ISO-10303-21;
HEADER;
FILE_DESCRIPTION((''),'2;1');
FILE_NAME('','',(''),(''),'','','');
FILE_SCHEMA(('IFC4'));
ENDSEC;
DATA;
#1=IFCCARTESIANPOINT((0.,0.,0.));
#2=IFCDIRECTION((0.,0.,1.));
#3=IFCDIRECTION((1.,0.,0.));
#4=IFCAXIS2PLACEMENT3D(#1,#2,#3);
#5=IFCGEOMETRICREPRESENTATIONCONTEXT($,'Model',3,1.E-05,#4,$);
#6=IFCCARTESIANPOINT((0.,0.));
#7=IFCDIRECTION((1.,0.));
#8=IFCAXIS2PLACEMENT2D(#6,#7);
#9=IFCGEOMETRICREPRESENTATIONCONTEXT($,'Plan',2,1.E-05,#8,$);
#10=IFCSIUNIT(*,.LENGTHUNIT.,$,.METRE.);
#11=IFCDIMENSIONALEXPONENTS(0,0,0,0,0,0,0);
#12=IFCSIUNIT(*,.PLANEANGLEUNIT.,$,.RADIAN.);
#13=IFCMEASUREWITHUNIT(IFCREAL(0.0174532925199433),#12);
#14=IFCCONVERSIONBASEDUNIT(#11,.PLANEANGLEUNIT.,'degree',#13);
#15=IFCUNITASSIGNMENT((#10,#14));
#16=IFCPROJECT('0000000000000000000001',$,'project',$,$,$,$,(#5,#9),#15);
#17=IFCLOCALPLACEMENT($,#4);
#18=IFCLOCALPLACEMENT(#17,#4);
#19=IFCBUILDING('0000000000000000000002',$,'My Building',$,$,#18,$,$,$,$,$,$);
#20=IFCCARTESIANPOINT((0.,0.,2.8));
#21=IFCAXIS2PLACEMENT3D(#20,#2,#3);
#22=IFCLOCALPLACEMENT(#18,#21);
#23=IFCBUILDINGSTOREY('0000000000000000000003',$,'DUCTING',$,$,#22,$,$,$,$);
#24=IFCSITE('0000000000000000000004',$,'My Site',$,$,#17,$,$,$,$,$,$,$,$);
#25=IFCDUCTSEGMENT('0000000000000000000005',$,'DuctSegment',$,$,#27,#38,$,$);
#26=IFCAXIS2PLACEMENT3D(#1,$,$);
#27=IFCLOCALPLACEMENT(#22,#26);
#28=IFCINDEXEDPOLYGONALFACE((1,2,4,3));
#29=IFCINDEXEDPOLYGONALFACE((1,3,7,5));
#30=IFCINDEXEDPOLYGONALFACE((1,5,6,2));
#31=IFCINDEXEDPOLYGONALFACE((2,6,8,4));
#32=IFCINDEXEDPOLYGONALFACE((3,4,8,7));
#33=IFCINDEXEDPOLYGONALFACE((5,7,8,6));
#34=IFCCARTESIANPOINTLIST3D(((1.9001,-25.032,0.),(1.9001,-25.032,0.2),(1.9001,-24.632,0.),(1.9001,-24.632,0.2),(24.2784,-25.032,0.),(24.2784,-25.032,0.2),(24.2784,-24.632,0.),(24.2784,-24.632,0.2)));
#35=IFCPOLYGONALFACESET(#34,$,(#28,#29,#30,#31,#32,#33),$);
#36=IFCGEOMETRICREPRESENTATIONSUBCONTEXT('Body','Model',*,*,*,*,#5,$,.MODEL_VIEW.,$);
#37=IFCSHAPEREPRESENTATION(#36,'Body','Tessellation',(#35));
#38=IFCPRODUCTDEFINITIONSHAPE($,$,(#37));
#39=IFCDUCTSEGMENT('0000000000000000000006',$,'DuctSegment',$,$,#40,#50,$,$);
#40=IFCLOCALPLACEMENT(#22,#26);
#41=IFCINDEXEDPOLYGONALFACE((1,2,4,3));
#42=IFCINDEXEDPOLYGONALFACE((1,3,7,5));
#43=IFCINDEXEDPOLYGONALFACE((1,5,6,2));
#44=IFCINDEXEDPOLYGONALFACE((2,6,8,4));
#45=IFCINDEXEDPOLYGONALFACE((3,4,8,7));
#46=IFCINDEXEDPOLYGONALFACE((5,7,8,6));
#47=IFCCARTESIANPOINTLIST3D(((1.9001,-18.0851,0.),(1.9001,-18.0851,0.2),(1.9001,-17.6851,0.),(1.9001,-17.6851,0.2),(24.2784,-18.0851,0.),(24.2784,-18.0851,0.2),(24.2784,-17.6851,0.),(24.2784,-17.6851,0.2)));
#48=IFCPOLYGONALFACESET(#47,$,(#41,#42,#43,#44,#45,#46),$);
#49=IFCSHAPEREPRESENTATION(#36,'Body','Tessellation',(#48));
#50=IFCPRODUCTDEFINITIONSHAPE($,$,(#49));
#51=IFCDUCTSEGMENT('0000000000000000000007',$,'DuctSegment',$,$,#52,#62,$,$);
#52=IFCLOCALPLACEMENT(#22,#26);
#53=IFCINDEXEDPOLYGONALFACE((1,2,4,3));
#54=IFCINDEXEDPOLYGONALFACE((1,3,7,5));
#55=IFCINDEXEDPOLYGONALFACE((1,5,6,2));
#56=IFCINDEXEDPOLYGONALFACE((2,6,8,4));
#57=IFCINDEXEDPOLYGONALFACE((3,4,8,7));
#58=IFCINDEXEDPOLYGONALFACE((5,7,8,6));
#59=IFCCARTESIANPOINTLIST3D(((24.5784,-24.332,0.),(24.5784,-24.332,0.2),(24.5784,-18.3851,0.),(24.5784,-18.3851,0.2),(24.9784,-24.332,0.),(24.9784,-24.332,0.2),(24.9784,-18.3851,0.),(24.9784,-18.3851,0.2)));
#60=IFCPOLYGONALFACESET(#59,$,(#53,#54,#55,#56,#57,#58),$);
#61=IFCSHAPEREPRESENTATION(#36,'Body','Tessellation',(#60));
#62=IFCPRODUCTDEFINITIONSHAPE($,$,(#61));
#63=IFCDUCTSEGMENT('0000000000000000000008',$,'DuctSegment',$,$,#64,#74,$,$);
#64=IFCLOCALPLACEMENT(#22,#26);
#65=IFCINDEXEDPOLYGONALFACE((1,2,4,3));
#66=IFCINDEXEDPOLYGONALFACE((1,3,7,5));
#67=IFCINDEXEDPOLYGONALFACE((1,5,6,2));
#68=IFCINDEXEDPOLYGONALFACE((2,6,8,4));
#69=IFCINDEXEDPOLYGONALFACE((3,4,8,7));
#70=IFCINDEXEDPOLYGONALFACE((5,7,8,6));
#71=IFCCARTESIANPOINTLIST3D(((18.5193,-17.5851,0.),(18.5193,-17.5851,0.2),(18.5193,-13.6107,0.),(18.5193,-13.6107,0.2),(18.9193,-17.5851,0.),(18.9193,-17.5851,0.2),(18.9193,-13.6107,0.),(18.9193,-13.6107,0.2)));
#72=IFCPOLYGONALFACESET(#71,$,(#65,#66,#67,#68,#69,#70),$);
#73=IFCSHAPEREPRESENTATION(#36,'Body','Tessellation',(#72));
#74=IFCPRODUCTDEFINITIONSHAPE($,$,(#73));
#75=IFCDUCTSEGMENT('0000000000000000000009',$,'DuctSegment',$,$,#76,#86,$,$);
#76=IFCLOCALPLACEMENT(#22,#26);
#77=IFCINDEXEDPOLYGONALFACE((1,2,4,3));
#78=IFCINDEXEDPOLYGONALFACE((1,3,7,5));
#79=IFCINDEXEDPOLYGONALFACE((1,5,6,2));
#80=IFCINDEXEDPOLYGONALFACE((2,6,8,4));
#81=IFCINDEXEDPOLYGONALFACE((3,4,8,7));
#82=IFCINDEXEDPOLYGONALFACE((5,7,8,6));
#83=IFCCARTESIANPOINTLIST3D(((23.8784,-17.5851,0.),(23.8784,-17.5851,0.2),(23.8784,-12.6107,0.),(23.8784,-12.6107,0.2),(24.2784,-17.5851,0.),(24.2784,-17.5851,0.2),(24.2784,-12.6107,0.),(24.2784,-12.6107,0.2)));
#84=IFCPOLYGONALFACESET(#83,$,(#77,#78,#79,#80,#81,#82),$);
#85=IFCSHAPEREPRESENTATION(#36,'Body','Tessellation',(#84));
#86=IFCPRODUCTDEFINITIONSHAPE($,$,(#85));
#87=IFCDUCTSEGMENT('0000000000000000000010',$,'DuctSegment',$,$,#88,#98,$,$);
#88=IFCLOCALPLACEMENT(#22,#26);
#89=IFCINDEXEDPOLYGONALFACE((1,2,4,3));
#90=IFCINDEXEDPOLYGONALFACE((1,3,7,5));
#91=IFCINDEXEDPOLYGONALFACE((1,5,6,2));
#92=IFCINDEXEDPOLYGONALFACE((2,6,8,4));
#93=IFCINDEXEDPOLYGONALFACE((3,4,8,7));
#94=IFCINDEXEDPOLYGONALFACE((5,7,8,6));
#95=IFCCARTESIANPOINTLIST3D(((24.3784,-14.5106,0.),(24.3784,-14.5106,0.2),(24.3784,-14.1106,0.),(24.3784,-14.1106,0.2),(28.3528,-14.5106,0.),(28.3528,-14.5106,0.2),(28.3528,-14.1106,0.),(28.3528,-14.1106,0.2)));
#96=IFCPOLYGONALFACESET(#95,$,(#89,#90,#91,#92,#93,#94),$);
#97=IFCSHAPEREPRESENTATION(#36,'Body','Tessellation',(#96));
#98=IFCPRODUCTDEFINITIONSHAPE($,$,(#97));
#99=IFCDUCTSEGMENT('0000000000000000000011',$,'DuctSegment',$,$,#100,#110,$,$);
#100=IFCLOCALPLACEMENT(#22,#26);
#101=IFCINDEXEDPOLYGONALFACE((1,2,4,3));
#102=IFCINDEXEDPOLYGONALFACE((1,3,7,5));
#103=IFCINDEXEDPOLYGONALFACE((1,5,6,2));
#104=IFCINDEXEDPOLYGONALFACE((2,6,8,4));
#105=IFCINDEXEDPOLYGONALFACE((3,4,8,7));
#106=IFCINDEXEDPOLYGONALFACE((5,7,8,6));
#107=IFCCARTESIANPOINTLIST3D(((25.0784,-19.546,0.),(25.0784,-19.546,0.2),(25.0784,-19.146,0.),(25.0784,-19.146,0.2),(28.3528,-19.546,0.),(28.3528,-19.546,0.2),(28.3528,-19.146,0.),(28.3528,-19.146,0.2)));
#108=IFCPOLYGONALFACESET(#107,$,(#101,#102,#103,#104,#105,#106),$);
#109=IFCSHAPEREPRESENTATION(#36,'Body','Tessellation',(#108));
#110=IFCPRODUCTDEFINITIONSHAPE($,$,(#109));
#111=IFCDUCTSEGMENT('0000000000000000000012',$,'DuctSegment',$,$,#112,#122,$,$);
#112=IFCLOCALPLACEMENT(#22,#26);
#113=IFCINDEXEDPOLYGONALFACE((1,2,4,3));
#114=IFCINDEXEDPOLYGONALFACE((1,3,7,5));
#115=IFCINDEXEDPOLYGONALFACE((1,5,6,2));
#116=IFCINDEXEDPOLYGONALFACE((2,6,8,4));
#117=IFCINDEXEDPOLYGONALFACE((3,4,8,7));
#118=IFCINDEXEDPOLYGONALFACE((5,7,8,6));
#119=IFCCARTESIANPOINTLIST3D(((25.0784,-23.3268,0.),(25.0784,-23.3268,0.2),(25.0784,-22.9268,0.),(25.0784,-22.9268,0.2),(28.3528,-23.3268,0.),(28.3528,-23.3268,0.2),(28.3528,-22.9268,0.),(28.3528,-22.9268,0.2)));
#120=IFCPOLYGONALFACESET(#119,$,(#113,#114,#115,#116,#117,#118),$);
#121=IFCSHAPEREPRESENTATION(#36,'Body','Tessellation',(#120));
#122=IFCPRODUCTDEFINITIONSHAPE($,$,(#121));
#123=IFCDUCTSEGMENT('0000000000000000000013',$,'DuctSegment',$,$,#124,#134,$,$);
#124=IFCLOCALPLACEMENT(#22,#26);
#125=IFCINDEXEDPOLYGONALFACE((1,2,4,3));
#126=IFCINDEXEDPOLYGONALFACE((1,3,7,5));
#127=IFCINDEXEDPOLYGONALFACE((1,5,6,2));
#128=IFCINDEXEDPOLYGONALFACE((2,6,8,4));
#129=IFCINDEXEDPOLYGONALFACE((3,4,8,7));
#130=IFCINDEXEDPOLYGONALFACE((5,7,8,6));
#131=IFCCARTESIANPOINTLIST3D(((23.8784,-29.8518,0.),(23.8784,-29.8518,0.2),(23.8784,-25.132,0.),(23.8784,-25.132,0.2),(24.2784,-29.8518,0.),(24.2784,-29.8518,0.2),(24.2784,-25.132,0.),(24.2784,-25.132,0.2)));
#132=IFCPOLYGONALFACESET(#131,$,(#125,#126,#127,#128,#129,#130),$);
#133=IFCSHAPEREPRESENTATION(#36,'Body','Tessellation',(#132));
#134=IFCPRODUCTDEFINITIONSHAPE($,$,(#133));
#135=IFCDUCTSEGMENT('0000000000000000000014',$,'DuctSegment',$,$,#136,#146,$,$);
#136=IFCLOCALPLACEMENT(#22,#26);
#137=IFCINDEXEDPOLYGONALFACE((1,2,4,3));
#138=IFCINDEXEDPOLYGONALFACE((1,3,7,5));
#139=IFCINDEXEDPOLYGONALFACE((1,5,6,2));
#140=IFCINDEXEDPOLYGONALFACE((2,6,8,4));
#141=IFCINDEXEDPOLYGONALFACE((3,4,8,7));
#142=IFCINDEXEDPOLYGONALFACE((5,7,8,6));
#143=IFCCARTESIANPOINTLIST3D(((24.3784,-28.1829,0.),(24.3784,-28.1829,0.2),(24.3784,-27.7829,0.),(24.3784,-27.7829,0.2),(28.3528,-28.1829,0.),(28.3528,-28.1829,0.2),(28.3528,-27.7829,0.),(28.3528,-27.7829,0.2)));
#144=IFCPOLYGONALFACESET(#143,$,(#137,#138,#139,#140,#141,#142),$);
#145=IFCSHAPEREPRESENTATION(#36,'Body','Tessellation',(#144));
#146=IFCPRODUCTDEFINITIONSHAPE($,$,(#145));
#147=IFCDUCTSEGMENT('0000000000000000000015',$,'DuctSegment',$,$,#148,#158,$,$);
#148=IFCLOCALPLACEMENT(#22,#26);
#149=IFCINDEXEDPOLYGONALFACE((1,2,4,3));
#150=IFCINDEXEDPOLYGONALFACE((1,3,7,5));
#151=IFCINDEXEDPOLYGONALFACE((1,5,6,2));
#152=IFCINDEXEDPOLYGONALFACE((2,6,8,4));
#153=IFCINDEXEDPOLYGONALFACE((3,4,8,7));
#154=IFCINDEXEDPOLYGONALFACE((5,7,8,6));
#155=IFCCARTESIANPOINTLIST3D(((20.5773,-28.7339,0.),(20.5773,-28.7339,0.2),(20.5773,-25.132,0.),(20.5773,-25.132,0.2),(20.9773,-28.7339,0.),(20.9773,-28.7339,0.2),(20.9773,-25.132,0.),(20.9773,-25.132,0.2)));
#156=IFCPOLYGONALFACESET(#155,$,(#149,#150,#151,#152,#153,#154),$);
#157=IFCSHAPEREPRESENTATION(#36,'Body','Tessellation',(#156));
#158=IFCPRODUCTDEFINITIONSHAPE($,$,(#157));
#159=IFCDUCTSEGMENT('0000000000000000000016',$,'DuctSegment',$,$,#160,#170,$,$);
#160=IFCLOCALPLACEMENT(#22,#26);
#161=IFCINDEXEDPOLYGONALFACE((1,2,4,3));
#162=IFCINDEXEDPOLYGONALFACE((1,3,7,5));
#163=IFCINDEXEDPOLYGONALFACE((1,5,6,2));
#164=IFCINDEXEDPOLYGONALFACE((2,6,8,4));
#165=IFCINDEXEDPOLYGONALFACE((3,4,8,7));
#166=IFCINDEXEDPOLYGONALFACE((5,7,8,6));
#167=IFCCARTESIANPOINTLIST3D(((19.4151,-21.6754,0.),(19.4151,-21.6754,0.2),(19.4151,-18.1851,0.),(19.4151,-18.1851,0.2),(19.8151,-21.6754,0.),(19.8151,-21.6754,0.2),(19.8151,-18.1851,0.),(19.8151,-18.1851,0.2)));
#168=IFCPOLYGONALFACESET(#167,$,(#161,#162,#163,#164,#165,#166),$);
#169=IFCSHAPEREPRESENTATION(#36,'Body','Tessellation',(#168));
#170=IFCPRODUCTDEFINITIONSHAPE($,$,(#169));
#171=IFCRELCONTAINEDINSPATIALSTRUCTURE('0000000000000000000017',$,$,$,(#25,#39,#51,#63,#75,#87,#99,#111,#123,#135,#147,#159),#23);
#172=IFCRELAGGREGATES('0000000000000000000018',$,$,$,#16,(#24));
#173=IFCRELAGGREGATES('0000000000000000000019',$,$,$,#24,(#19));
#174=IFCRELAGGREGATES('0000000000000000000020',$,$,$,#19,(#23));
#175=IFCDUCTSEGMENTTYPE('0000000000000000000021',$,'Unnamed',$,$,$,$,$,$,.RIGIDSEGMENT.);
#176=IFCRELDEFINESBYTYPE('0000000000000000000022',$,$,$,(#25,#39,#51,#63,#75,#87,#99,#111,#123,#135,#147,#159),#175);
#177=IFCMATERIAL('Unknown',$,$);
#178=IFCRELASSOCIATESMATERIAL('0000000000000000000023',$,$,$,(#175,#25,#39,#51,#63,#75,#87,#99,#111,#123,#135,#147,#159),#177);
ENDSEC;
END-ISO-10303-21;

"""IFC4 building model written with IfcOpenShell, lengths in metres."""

from ifc_helpers import new_model, entity, si_unit, converted_unit, frame, origin_with_axes, origin_2d_with_axis, place, context, subcontext, project, spatial, rectangle, extrude, material, material_profile, profile_set, profile_usage, type_object, element, save


model = new_model("IFC4")

# Units and contexts
model_context = context("Model", 3, precision=1e-05, world=origin_with_axes())
plan_context = context("Plan", 2, precision=1e-05, world=origin_2d_with_axis())
body_context = subcontext(model_context, "Body", "Model", "MODEL_VIEW")
ifc_project = project(units=[si_unit("LENGTHUNIT", "METRE"), converted_unit("PLANEANGLEUNIT", "degree", entity("IfcReal", 0.0174532925199433), si_unit("PLANEANGLEUNIT", "RADIAN"), dimensions=[0, 0, 0, 0, 0, 0, 0])], contexts=[model_context, plan_context])

# Site, building, storey
site_placement = place(None, origin_with_axes())
site = spatial("IfcSite", under=ifc_project, at=site_placement, Name="My Site")
building_placement = place(site_placement, origin_with_axes())
building = spatial("IfcBuilding", under=site, at=building_placement, Name="My Building")
storey_placement = place(building_placement, frame((0.0, 0.0, 2.8), z_axis=(0.0, 0.0, 1.0), x_axis=(1.0, 0.0, 0.0)))
storey = spatial("IfcBuildingStorey", under=building, at=storey_placement, Name="DUCTING")

# Duct segments
ifc_material = material(Name="Unknown")
ifc_material_profile_1 = material_profile(ifc_material, rectangle(XDim=0.4, YDim=0.2))
ifc_profile_set_1 = profile_set([ifc_material_profile_1])
ifc_profile_usage_1 = profile_usage(ifc_profile_set_1, cardinal=5)
duct_segment_type = type_object("IfcDuctSegmentType", Name="Unnamed", PredefinedType="RIGIDSEGMENT", material=ifc_profile_set_1)
duct_segment_1_placement = place(storey_placement, frame((24.2784, -24.832, 0.1), z_axis=(-1.0, 0.0, 0.000001), x_axis=(0.0, -1.0, 0.0)))
element("IfcDuctSegment", 1, at=duct_segment_1_placement, inside=storey, type_object=duct_segment_type, material=ifc_profile_usage_1, Name="DuctSegment", context=body_context, shape_type="SweptSolid", body=[
    extrude(rectangle(XDim=0.4, YDim=0.2), origin_with_axes(), (0.0, 0.0, 1.0), 22.3784),
])
ifc_profile_usage_2 = profile_usage(ifc_profile_set_1, cardinal=5)
duct_segment_2_placement = place(storey_placement, frame((24.2784, -17.8851, 0.1), z_axis=(-1.0, 0.0, 0.000001), x_axis=(0.0, -1.0, 0.0)))
element("IfcDuctSegment", 2, at=duct_segment_2_placement, inside=storey, type_object=duct_segment_type, material=ifc_profile_usage_2, Name="DuctSegment", context=body_context, shape_type="SweptSolid", body=[
    extrude(rectangle(XDim=0.4, YDim=0.2), origin_with_axes(), (0.0, 0.0, 1.0), 22.3784),
])
ifc_profile_usage_3 = profile_usage(ifc_profile_set_1, cardinal=5)
duct_segment_3_placement = place(storey_placement, frame((24.7784, -24.332, 0.1), z_axis=(0.0, 1.0, 0.0), x_axis=(-1.0, 0.0, 0.0)))
element("IfcDuctSegment", 3, at=duct_segment_3_placement, inside=storey, type_object=duct_segment_type, material=ifc_profile_usage_3, Name="DuctSegment", context=body_context, shape_type="SweptSolid", body=[
    extrude(rectangle(XDim=0.4, YDim=0.2), origin_with_axes(), (0.0, 0.0, 1.0), 5.9469),
])
ifc_profile_usage_4 = profile_usage(ifc_profile_set_1, cardinal=5)
duct_segment_4_placement = place(storey_placement, frame((18.7193, -17.5851, 0.1), z_axis=(0.0, 1.0, 0.0), x_axis=(-1.0, 0.0, 0.0)))
element("IfcDuctSegment", 4, at=duct_segment_4_placement, inside=storey, type_object=duct_segment_type, material=ifc_profile_usage_4, Name="DuctSegment", context=body_context, shape_type="SweptSolid", body=[
    extrude(rectangle(XDim=0.4, YDim=0.2), origin_with_axes(), (0.0, 0.0, 1.0), 3.9744),
])
ifc_profile_usage_5 = profile_usage(ifc_profile_set_1, cardinal=5)
duct_segment_5_placement = place(storey_placement, frame((24.0784, -17.5851, 0.1), z_axis=(0.0, 1.0, 0.0), x_axis=(-1.0, 0.0, 0.0)))
element("IfcDuctSegment", 5, at=duct_segment_5_placement, inside=storey, type_object=duct_segment_type, material=ifc_profile_usage_5, Name="DuctSegment", context=body_context, shape_type="SweptSolid", body=[
    extrude(rectangle(XDim=0.4, YDim=0.2), origin_with_axes(), (0.0, 0.0, 1.0), 4.9744),
])
ifc_profile_usage_6 = profile_usage(ifc_profile_set_1, cardinal=5)
duct_segment_6_placement = place(storey_placement, frame((24.3784, -14.3106, 0.1), z_axis=(1.0, 0.0, 0.0), x_axis=(0.0, 1.0, 0.0)))
element("IfcDuctSegment", 6, at=duct_segment_6_placement, inside=storey, type_object=duct_segment_type, material=ifc_profile_usage_6, Name="DuctSegment", context=body_context, shape_type="SweptSolid", body=[
    extrude(rectangle(XDim=0.4, YDim=0.2), origin_with_axes(), (0.0, 0.0, 1.0), 3.9744),
])
ifc_profile_usage_7 = profile_usage(ifc_profile_set_1, cardinal=5)
duct_segment_7_placement = place(storey_placement, frame((25.0784, -19.346, 0.1), z_axis=(1.0, 0.0, 0.0), x_axis=(0.0, 1.0, 0.0)))
element("IfcDuctSegment", 7, at=duct_segment_7_placement, inside=storey, type_object=duct_segment_type, material=ifc_profile_usage_7, Name="DuctSegment", context=body_context, shape_type="SweptSolid", body=[
    extrude(rectangle(XDim=0.4, YDim=0.2), origin_with_axes(), (0.0, 0.0, 1.0), 3.2744),
])
ifc_profile_usage_8 = profile_usage(ifc_profile_set_1, cardinal=5)
duct_segment_8_placement = place(storey_placement, frame((25.0784, -23.1268, 0.1), z_axis=(1.0, 0.0, 0.0), x_axis=(0.0, 1.0, 0.0)))
element("IfcDuctSegment", 8, at=duct_segment_8_placement, inside=storey, type_object=duct_segment_type, material=ifc_profile_usage_8, Name="DuctSegment", context=body_context, shape_type="SweptSolid", body=[
    extrude(rectangle(XDim=0.4, YDim=0.2), origin_with_axes(), (0.0, 0.0, 1.0), 3.2744),
])
ifc_profile_usage_9 = profile_usage(ifc_profile_set_1, cardinal=5)
duct_segment_9_placement = place(storey_placement, frame((24.0784, -25.132, 0.1), z_axis=(0.0, -1.0, 0.0), x_axis=(1.0, 0.0, 0.0)))
element("IfcDuctSegment", 9, at=duct_segment_9_placement, inside=storey, type_object=duct_segment_type, material=ifc_profile_usage_9, Name="DuctSegment", context=body_context, shape_type="SweptSolid", body=[
    extrude(rectangle(XDim=0.4, YDim=0.2), origin_with_axes(), (0.0, 0.0, 1.0), 4.7198),
])
ifc_profile_usage_10 = profile_usage(ifc_profile_set_1, cardinal=5)
duct_segment_10_placement = place(storey_placement, frame((24.3784, -27.9829, 0.1), z_axis=(1.0, 0.0, 0.0), x_axis=(0.0, 1.0, 0.0)))
element("IfcDuctSegment", 10, at=duct_segment_10_placement, inside=storey, type_object=duct_segment_type, material=ifc_profile_usage_10, Name="DuctSegment", context=body_context, shape_type="SweptSolid", body=[
    extrude(rectangle(XDim=0.4, YDim=0.2), origin_with_axes(), (0.0, 0.0, 1.0), 3.9744),
])
ifc_profile_usage_11 = profile_usage(ifc_profile_set_1, cardinal=5)
duct_segment_11_placement = place(storey_placement, frame((20.7773, -25.132, 0.1), z_axis=(0.0, -1.0, 0.0), x_axis=(1.0, 0.0, 0.0)))
element("IfcDuctSegment", 11, at=duct_segment_11_placement, inside=storey, type_object=duct_segment_type, material=ifc_profile_usage_11, Name="DuctSegment", context=body_context, shape_type="SweptSolid", body=[
    extrude(rectangle(XDim=0.4, YDim=0.2), origin_with_axes(), (0.0, 0.0, 1.0), 3.6018),
])
ifc_profile_usage_12 = profile_usage(ifc_profile_set_1, cardinal=5)
duct_segment_12_placement = place(storey_placement, frame((19.6151, -18.1851, 0.1), z_axis=(0.0, -1.0, 0.0), x_axis=(1.0, 0.0, 0.0)))
element("IfcDuctSegment", 12, at=duct_segment_12_placement, inside=storey, type_object=duct_segment_type, material=ifc_profile_usage_12, Name="DuctSegment", context=body_context, shape_type="SweptSolid", body=[
    extrude(rectangle(XDim=0.4, YDim=0.2), origin_with_axes(), (0.0, 0.0, 1.0), 3.4903),
])

save(model, "model.ifc")
